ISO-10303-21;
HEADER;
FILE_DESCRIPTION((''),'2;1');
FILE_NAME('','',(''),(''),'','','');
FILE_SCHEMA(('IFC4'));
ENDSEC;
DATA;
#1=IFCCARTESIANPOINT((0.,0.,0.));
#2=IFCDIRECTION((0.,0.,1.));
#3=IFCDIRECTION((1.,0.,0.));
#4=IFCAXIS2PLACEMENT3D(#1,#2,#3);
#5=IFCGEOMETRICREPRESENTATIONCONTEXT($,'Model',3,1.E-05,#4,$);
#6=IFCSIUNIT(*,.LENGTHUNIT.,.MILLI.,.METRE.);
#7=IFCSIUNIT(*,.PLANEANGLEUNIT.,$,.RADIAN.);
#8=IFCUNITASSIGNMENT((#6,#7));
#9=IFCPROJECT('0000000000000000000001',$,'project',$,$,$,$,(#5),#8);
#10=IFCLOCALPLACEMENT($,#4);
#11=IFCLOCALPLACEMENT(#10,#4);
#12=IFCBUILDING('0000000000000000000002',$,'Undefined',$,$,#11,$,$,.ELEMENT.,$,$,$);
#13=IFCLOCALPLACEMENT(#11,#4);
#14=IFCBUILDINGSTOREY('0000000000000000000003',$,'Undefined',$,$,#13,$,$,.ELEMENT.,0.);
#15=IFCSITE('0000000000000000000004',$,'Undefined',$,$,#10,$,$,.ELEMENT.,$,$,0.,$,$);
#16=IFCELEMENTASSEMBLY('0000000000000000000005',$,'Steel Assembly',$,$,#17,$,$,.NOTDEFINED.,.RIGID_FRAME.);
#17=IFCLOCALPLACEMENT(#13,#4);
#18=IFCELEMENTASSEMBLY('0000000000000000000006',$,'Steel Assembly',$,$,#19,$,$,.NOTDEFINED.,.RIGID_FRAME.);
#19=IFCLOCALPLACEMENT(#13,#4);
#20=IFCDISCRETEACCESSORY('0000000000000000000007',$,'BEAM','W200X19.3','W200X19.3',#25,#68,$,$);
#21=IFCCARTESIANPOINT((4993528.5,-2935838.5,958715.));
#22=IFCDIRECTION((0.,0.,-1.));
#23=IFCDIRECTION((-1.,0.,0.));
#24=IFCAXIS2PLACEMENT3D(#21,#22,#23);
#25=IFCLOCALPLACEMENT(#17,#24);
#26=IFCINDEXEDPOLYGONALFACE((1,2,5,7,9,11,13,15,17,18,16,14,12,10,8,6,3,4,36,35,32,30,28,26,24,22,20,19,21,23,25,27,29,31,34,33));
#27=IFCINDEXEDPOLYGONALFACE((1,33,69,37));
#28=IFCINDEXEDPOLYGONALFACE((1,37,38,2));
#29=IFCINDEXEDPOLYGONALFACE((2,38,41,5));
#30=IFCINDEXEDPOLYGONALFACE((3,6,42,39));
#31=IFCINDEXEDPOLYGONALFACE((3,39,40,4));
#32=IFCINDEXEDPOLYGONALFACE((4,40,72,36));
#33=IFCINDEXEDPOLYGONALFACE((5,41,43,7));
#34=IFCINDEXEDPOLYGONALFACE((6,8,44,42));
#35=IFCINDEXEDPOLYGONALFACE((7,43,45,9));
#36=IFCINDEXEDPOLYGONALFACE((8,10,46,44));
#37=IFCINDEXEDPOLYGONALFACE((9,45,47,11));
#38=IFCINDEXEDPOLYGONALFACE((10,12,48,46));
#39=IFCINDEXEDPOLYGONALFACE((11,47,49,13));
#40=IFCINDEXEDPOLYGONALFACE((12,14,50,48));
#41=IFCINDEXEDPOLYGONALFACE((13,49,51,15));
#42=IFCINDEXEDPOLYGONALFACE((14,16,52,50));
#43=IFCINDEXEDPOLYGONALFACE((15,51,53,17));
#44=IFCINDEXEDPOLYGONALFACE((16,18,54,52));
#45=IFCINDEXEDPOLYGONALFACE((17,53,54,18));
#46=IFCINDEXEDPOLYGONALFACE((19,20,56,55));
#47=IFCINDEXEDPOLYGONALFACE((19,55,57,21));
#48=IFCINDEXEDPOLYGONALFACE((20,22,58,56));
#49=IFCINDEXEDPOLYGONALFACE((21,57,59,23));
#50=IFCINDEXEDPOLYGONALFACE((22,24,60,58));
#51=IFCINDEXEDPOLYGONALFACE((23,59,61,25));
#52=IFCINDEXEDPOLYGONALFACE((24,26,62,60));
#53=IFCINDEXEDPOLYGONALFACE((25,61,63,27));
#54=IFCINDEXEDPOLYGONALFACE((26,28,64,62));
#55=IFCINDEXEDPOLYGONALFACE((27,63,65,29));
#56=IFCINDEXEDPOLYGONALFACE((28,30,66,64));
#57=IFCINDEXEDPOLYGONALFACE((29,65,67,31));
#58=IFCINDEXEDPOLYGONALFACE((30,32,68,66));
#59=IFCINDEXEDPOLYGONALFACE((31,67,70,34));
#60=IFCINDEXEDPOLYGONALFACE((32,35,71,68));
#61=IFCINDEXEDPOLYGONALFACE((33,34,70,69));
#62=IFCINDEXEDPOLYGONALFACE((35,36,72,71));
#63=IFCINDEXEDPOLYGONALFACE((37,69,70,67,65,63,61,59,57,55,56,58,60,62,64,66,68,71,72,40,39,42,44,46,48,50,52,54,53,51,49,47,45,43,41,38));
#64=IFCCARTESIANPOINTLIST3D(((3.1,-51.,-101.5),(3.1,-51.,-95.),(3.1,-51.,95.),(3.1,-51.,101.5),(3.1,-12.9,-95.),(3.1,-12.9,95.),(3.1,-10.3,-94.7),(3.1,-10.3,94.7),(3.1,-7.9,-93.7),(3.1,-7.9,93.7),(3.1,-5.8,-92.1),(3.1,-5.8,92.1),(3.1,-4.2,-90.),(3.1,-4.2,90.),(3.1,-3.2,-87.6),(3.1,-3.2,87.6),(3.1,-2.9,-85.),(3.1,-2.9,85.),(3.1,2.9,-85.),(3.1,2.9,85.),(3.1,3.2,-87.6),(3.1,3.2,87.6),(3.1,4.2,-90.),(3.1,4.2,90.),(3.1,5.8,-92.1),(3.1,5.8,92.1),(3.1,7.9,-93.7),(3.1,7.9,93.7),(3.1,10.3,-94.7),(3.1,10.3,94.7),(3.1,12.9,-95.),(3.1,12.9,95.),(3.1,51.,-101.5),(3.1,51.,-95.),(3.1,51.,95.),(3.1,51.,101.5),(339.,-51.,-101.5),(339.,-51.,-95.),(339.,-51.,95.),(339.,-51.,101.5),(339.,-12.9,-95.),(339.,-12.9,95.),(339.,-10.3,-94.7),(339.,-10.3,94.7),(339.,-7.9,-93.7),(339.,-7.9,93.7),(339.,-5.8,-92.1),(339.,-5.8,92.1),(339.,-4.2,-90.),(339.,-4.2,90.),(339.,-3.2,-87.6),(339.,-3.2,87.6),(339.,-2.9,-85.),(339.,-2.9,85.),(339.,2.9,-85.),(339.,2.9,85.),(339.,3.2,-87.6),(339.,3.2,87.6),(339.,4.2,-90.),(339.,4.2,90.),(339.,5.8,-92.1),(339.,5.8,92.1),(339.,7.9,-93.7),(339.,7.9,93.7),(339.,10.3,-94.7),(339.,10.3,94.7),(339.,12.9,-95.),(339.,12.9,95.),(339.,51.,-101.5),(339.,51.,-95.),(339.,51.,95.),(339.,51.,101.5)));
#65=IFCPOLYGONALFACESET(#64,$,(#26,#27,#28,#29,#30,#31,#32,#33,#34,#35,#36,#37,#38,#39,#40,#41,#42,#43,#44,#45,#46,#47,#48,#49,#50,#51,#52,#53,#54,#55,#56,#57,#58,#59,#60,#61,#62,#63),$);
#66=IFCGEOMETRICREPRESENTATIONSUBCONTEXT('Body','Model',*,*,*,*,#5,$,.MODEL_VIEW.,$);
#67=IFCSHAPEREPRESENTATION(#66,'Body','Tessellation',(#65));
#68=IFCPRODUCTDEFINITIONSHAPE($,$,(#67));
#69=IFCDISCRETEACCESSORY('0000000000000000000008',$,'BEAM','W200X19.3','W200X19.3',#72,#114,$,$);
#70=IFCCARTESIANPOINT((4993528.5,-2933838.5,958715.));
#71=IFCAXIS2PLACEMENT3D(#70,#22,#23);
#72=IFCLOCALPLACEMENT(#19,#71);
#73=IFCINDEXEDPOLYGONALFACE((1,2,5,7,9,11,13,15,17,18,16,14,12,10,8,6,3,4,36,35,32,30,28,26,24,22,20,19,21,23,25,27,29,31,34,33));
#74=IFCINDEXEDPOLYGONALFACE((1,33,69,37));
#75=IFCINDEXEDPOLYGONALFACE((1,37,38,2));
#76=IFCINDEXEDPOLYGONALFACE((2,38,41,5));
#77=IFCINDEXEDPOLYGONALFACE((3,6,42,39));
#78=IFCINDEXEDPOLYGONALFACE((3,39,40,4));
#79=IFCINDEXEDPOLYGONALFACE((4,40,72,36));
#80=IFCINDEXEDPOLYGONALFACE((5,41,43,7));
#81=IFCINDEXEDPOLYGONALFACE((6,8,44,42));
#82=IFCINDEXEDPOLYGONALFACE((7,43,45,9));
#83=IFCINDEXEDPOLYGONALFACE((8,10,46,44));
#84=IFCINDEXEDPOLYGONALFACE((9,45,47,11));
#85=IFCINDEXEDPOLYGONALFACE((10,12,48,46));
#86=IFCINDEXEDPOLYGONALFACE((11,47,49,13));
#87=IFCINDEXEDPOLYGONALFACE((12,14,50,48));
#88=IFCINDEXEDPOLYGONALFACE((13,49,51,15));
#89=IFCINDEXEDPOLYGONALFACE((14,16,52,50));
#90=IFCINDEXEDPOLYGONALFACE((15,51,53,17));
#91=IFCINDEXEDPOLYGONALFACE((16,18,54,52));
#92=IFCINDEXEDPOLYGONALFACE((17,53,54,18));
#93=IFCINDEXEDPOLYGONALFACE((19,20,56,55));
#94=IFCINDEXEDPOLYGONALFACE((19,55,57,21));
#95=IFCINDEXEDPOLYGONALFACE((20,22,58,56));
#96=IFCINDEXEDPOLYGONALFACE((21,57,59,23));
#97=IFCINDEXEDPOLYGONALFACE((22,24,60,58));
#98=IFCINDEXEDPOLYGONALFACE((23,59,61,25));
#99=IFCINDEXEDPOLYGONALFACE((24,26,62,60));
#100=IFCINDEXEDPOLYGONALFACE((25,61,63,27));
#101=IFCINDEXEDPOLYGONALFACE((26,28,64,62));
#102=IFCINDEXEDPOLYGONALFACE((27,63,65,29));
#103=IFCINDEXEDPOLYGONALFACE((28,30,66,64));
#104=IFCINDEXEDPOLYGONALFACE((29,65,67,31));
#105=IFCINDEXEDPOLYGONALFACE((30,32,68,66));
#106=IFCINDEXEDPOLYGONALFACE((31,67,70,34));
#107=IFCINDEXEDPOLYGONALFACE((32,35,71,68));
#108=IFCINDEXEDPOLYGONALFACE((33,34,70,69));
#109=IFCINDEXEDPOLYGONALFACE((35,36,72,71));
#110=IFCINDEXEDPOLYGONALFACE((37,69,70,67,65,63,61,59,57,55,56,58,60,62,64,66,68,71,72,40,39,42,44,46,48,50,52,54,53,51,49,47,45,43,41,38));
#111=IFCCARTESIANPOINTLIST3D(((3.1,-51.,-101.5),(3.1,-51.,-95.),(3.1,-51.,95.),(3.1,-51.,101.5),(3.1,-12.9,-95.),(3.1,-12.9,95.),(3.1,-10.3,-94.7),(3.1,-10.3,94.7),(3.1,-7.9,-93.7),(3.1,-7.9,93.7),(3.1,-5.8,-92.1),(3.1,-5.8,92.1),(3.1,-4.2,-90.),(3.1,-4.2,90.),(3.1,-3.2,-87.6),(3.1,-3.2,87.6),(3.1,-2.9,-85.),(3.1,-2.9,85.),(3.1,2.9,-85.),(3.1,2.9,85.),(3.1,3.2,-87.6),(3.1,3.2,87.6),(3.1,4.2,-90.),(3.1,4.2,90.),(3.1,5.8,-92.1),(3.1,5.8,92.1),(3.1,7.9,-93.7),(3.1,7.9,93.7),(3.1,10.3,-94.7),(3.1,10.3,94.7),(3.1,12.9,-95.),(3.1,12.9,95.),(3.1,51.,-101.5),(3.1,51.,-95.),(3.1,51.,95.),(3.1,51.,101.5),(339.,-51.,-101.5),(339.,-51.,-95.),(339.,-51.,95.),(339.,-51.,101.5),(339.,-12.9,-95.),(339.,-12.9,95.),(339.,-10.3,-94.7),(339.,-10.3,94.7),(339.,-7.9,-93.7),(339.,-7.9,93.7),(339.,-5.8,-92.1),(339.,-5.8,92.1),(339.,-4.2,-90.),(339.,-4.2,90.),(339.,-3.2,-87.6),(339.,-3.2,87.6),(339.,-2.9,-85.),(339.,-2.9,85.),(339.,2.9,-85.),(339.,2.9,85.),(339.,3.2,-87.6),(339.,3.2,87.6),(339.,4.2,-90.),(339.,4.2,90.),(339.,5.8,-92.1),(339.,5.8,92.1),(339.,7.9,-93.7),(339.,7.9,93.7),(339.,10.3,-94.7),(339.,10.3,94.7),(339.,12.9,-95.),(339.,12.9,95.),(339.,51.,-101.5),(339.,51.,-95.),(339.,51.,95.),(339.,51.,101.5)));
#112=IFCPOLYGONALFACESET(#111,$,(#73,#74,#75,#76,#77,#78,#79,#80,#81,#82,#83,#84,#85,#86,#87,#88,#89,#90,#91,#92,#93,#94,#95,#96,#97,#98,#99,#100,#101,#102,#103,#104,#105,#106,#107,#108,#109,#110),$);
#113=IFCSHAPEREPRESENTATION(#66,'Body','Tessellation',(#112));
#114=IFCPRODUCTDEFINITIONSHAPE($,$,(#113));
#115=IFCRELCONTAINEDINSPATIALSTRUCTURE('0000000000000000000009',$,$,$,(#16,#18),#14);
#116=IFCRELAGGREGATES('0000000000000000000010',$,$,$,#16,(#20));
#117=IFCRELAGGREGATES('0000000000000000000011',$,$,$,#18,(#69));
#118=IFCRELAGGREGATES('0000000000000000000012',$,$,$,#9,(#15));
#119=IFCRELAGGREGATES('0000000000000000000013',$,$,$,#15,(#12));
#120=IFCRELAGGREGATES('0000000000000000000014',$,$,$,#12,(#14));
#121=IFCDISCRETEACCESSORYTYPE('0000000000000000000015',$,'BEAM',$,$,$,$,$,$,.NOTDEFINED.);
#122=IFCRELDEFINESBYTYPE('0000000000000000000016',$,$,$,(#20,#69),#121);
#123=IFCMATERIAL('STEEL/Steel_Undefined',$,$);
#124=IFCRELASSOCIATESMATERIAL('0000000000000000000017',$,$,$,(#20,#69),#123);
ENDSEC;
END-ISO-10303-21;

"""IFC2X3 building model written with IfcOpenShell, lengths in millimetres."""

from ifc_helpers import new_model, si_unit, frame, origin_with_axes, origin_2d_with_axis, place, context, subcontext, project, spatial, i_section, extrude, clip, halfspace, material, type_object, element, aggregate, save


model = new_model("IFC2X3")

# Units and contexts
model_context = context("Model", 3, precision=1e-05, world=origin_with_axes())
body_context = subcontext(model_context, "Body", "Model", "MODEL_VIEW")
ifc_project = project(units=[si_unit("LENGTHUNIT", "METRE", prefix="MILLI"), si_unit("PLANEANGLEUNIT", "RADIAN")], contexts=[model_context])

# Site, building, storey
site_placement = place(None, origin_with_axes())
site = spatial("IfcSite", under=ifc_project, at=site_placement, Name="Undefined", CompositionType="ELEMENT", RefElevation=0.0)
building_placement = place(site_placement, origin_with_axes())
building = spatial("IfcBuilding", under=site, at=building_placement, Name="Undefined", CompositionType="ELEMENT")
storey_placement = place(building_placement, origin_with_axes())
storey = spatial("IfcBuildingStorey", under=building, at=storey_placement, Name="Undefined", CompositionType="ELEMENT", Elevation=0.0)

# Shared definitions
ifc_material_1 = material(Name="STEEL/Steel_Undefined")

# Element assembly
assembly_1_placement = place(storey_placement, origin_with_axes())
assembly_1 = element("IfcElementAssembly", 1, at=assembly_1_placement, inside=storey, Name="Steel Assembly", AssemblyPlace="NOTDEFINED", PredefinedType="RIGID_FRAME")

# Element assembly
assembly_2_placement = place(storey_placement, origin_with_axes())
assembly_2 = element("IfcElementAssembly", 2, at=assembly_2_placement, inside=storey, Name="Steel Assembly", AssemblyPlace="NOTDEFINED", PredefinedType="RIGID_FRAME")

# Discrete accessories
discrete_accessory_type_1 = type_object("IfcDiscreteAccessoryType", Name="BEAM")
discrete_accessory_1_placement = place(assembly_1_placement, frame((4993528.5, -2935838.5, 958715.0), z_axis=(0.0, 0.0, -1.0), x_axis=(-1.0, 0.0, 0.0)))
discrete_accessory_1 = element("IfcDiscreteAccessory", 3, at=discrete_accessory_1_placement, type_object=discrete_accessory_type_1, material=ifc_material_1, Name="BEAM", Description="W200X19.3", ObjectType="W200X19.3", context=body_context, shape_type="Clipping", body=[
    clip(clip(extrude(i_section(OverallWidth=102.0, OverallDepth=203.0, WebThickness=5.8, FlangeThickness=6.5, FilletRadius=10.0, at=origin_2d_with_axis()), frame((339.0, 0.0, 0.0), z_axis=(-1.0, 0.0, 0.0), x_axis=(0.0, -1.0, 0.0)), (0.0, 0.0, 1.0), 335.9), halfspace(frame((339.0, 0.0, -1000.0), z_axis=(-1.0, 0.0, 0.0), x_axis=(0.0, 1.0, 0.0)), True)), halfspace(frame((3.1, 0.0, -1101.5), z_axis=(-1.0, 0.0, 0.0), x_axis=(0.0, 1.0, 0.0)), False)),
])
aggregate(assembly_1, [discrete_accessory_1])
discrete_accessory_2_placement = place(assembly_2_placement, frame((4993528.5, -2933838.5, 958715.0), z_axis=(0.0, 0.0, -1.0), x_axis=(-1.0, 0.0, 0.0)))
discrete_accessory_2 = element("IfcDiscreteAccessory", 4, at=discrete_accessory_2_placement, type_object=discrete_accessory_type_1, material=ifc_material_1, Name="BEAM", Description="W200X19.3", ObjectType="W200X19.3", context=body_context, shape_type="Clipping", body=[
    clip(clip(extrude(i_section(OverallWidth=102.0, OverallDepth=203.0, WebThickness=5.8, FlangeThickness=6.5, FilletRadius=10.0, at=origin_2d_with_axis()), frame((339.0, 0.0, 0.0), z_axis=(-1.0, 0.0, 0.0), x_axis=(0.0, -1.0, 0.0)), (0.0, 0.0, 1.0), 335.9), halfspace(frame((339.0, 0.0, -1000.0), z_axis=(-1.0, 0.0, 0.0), x_axis=(0.0, 1.0, 0.0)), True)), halfspace(frame((3.1, 0.0, -1101.5), z_axis=(-1.0, 0.0, 0.0), x_axis=(0.0, 1.0, 0.0)), False)),
])
aggregate(assembly_2, [discrete_accessory_2])

save(model, "model.ifc")
